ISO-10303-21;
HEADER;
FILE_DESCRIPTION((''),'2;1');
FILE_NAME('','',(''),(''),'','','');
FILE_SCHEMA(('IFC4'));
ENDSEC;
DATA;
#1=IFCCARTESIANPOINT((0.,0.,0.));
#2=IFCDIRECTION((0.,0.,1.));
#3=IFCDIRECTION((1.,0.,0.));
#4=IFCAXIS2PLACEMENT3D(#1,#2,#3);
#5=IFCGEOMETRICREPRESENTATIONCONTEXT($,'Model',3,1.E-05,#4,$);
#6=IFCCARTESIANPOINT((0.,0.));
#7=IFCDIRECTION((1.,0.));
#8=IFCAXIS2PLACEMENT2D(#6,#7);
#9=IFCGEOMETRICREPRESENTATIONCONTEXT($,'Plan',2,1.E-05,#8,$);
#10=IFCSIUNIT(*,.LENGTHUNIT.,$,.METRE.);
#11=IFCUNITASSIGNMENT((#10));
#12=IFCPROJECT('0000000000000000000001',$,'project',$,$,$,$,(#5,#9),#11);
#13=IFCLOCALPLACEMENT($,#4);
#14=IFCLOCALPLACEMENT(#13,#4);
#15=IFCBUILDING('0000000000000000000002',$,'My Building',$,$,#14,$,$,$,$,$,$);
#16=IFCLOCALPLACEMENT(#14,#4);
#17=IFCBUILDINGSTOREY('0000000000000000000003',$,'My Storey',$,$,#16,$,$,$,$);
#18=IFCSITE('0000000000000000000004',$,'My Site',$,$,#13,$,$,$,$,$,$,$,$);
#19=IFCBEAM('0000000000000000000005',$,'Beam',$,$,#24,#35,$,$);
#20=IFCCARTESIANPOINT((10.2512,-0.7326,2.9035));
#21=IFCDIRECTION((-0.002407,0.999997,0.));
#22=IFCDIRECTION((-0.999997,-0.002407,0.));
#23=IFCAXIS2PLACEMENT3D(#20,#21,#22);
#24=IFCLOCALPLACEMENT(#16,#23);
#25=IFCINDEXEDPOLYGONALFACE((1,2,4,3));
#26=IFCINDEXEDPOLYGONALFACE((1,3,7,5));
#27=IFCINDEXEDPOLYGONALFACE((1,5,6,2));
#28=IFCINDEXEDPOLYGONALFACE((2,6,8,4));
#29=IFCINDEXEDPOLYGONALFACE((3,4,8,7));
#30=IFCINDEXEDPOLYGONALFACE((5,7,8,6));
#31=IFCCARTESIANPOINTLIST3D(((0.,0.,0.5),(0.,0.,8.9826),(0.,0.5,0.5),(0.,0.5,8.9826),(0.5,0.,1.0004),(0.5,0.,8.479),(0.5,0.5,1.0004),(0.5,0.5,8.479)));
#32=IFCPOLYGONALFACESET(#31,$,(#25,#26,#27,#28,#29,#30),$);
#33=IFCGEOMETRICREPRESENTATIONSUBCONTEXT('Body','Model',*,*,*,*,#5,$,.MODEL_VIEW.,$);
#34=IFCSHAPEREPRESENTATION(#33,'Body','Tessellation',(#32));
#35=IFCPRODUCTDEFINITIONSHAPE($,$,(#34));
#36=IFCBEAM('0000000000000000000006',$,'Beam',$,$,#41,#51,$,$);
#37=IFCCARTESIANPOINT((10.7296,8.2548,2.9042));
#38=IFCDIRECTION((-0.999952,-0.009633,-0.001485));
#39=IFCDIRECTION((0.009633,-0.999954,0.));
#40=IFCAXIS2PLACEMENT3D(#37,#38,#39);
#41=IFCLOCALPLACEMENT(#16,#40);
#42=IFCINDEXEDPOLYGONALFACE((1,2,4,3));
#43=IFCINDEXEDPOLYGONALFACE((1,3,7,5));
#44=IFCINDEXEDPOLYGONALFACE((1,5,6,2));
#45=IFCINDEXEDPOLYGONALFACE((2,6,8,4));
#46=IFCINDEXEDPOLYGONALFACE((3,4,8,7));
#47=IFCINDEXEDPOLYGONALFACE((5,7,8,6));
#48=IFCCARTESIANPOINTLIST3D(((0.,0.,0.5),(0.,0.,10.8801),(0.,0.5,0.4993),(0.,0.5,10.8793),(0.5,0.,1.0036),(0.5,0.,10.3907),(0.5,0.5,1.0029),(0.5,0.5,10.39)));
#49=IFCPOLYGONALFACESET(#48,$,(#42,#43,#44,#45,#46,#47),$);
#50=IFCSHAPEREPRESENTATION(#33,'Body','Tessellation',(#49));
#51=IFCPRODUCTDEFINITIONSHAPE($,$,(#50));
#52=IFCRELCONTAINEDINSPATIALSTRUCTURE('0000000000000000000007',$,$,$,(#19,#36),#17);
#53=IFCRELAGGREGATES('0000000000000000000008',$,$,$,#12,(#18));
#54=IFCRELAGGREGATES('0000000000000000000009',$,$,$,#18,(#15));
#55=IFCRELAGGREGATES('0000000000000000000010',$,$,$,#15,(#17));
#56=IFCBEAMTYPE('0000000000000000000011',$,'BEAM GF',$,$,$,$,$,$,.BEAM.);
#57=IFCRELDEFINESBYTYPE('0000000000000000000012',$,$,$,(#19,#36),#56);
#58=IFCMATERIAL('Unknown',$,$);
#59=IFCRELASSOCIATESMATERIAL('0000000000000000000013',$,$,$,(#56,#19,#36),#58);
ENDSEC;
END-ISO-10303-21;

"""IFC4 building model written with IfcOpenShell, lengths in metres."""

from ifc_helpers import new_model, si_unit, frame, origin_with_axes, origin_2d_with_axis, place, context, subcontext, project, spatial, rectangle, extrude, clip, halfspace, material, material_profile, profile_set, profile_usage, type_object, element, save


model = new_model("IFC4")

# Units and contexts
model_context = context("Model", 3, precision=1e-05, world=origin_with_axes())
plan_context = context("Plan", 2, precision=1e-05, world=origin_2d_with_axis())
body_context_1 = subcontext(model_context, "Body", "Model", "MODEL_VIEW")
ifc_project = project(units=[si_unit("LENGTHUNIT", "METRE")], contexts=[model_context, plan_context])

# Site, building, storey
site_placement = place(None, origin_with_axes())
site = spatial("IfcSite", under=ifc_project, at=site_placement, Name="My Site")
building_placement = place(site_placement, origin_with_axes())
building = spatial("IfcBuilding", under=site, at=building_placement, Name="My Building")
storey_placement = place(building_placement, origin_with_axes())
storey = spatial("IfcBuildingStorey", under=building, at=storey_placement, Name="My Storey")

# Shared definitions
ifc_material = material(Name="Unknown")

# Beams
ifc_material_profile_1 = material_profile(ifc_material, rectangle(XDim=0.5, YDim=0.5))
ifc_profile_set_1 = profile_set([ifc_material_profile_1])
ifc_profile_usage_1 = profile_usage(ifc_profile_set_1, cardinal=3)
beam_type = type_object("IfcBeamType", Name="BEAM GF", PredefinedType="BEAM", material=ifc_profile_set_1)
beam_1_placement = place(storey_placement, frame((10.2512, -0.7326, 2.9035), z_axis=(-0.002407, 0.999997, 0.0), x_axis=(-0.999997, -0.002407, 0.0)))
element("IfcBeam", 1, at=beam_1_placement, inside=storey, type_object=beam_type, material=ifc_profile_usage_1, Name="Beam", context=body_context_1, shape_type="Clipping", body=[
    clip(clip(extrude(rectangle(XDim=0.5, YDim=0.5), frame((0.25, 0.25, 0.0), z_axis=(0.0, 0.0, 1.0), x_axis=(1.0, 0.0, 0.0)), (0.0, 0.0, 1.0), 9.4826), halfspace(frame((0.0, -3.0, 8.9826), z_axis=(0.709658, 0.0, 0.704547), x_axis=(0.0, -1.0, 0.0)), False)), halfspace(frame((0.0, -3.0, 0.5), z_axis=(0.707372, 0.0, -0.706842), x_axis=(0.0, -1.0, 0.0)), False)),
])
ifc_profile_usage_2 = profile_usage(ifc_profile_set_1, cardinal=3)
beam_2_placement = place(storey_placement, frame((10.7296, 8.2548, 2.9042), z_axis=(-0.999952, -0.009633, -0.001485), x_axis=(0.009633, -0.999954, 0.0)))
element("IfcBeam", 2, at=beam_2_placement, inside=storey, type_object=beam_type, material=ifc_profile_usage_2, Name="Beam", context=body_context_1, shape_type="Clipping", body=[
    clip(clip(extrude(rectangle(XDim=0.5, YDim=0.5), frame((0.25, 0.25, 0.0), z_axis=(0.0, 0.0, 1.0), x_axis=(1.0, 0.0, 0.0)), (0.0, 0.0, 1.0), 11.3801), halfspace(frame((0.0, -2.9846, 10.8845), z_axis=(0.699451, 0.001061, 0.71468), x_axis=(0.001517, -0.999999, 0.0)), False)), halfspace(frame((0.0, -3.0, 0.5045), z_axis=(0.709657, -0.001046, -0.704547), x_axis=(-0.001474, -0.999999, 0.0)), False)),
])

save(model, "model.ifc")
